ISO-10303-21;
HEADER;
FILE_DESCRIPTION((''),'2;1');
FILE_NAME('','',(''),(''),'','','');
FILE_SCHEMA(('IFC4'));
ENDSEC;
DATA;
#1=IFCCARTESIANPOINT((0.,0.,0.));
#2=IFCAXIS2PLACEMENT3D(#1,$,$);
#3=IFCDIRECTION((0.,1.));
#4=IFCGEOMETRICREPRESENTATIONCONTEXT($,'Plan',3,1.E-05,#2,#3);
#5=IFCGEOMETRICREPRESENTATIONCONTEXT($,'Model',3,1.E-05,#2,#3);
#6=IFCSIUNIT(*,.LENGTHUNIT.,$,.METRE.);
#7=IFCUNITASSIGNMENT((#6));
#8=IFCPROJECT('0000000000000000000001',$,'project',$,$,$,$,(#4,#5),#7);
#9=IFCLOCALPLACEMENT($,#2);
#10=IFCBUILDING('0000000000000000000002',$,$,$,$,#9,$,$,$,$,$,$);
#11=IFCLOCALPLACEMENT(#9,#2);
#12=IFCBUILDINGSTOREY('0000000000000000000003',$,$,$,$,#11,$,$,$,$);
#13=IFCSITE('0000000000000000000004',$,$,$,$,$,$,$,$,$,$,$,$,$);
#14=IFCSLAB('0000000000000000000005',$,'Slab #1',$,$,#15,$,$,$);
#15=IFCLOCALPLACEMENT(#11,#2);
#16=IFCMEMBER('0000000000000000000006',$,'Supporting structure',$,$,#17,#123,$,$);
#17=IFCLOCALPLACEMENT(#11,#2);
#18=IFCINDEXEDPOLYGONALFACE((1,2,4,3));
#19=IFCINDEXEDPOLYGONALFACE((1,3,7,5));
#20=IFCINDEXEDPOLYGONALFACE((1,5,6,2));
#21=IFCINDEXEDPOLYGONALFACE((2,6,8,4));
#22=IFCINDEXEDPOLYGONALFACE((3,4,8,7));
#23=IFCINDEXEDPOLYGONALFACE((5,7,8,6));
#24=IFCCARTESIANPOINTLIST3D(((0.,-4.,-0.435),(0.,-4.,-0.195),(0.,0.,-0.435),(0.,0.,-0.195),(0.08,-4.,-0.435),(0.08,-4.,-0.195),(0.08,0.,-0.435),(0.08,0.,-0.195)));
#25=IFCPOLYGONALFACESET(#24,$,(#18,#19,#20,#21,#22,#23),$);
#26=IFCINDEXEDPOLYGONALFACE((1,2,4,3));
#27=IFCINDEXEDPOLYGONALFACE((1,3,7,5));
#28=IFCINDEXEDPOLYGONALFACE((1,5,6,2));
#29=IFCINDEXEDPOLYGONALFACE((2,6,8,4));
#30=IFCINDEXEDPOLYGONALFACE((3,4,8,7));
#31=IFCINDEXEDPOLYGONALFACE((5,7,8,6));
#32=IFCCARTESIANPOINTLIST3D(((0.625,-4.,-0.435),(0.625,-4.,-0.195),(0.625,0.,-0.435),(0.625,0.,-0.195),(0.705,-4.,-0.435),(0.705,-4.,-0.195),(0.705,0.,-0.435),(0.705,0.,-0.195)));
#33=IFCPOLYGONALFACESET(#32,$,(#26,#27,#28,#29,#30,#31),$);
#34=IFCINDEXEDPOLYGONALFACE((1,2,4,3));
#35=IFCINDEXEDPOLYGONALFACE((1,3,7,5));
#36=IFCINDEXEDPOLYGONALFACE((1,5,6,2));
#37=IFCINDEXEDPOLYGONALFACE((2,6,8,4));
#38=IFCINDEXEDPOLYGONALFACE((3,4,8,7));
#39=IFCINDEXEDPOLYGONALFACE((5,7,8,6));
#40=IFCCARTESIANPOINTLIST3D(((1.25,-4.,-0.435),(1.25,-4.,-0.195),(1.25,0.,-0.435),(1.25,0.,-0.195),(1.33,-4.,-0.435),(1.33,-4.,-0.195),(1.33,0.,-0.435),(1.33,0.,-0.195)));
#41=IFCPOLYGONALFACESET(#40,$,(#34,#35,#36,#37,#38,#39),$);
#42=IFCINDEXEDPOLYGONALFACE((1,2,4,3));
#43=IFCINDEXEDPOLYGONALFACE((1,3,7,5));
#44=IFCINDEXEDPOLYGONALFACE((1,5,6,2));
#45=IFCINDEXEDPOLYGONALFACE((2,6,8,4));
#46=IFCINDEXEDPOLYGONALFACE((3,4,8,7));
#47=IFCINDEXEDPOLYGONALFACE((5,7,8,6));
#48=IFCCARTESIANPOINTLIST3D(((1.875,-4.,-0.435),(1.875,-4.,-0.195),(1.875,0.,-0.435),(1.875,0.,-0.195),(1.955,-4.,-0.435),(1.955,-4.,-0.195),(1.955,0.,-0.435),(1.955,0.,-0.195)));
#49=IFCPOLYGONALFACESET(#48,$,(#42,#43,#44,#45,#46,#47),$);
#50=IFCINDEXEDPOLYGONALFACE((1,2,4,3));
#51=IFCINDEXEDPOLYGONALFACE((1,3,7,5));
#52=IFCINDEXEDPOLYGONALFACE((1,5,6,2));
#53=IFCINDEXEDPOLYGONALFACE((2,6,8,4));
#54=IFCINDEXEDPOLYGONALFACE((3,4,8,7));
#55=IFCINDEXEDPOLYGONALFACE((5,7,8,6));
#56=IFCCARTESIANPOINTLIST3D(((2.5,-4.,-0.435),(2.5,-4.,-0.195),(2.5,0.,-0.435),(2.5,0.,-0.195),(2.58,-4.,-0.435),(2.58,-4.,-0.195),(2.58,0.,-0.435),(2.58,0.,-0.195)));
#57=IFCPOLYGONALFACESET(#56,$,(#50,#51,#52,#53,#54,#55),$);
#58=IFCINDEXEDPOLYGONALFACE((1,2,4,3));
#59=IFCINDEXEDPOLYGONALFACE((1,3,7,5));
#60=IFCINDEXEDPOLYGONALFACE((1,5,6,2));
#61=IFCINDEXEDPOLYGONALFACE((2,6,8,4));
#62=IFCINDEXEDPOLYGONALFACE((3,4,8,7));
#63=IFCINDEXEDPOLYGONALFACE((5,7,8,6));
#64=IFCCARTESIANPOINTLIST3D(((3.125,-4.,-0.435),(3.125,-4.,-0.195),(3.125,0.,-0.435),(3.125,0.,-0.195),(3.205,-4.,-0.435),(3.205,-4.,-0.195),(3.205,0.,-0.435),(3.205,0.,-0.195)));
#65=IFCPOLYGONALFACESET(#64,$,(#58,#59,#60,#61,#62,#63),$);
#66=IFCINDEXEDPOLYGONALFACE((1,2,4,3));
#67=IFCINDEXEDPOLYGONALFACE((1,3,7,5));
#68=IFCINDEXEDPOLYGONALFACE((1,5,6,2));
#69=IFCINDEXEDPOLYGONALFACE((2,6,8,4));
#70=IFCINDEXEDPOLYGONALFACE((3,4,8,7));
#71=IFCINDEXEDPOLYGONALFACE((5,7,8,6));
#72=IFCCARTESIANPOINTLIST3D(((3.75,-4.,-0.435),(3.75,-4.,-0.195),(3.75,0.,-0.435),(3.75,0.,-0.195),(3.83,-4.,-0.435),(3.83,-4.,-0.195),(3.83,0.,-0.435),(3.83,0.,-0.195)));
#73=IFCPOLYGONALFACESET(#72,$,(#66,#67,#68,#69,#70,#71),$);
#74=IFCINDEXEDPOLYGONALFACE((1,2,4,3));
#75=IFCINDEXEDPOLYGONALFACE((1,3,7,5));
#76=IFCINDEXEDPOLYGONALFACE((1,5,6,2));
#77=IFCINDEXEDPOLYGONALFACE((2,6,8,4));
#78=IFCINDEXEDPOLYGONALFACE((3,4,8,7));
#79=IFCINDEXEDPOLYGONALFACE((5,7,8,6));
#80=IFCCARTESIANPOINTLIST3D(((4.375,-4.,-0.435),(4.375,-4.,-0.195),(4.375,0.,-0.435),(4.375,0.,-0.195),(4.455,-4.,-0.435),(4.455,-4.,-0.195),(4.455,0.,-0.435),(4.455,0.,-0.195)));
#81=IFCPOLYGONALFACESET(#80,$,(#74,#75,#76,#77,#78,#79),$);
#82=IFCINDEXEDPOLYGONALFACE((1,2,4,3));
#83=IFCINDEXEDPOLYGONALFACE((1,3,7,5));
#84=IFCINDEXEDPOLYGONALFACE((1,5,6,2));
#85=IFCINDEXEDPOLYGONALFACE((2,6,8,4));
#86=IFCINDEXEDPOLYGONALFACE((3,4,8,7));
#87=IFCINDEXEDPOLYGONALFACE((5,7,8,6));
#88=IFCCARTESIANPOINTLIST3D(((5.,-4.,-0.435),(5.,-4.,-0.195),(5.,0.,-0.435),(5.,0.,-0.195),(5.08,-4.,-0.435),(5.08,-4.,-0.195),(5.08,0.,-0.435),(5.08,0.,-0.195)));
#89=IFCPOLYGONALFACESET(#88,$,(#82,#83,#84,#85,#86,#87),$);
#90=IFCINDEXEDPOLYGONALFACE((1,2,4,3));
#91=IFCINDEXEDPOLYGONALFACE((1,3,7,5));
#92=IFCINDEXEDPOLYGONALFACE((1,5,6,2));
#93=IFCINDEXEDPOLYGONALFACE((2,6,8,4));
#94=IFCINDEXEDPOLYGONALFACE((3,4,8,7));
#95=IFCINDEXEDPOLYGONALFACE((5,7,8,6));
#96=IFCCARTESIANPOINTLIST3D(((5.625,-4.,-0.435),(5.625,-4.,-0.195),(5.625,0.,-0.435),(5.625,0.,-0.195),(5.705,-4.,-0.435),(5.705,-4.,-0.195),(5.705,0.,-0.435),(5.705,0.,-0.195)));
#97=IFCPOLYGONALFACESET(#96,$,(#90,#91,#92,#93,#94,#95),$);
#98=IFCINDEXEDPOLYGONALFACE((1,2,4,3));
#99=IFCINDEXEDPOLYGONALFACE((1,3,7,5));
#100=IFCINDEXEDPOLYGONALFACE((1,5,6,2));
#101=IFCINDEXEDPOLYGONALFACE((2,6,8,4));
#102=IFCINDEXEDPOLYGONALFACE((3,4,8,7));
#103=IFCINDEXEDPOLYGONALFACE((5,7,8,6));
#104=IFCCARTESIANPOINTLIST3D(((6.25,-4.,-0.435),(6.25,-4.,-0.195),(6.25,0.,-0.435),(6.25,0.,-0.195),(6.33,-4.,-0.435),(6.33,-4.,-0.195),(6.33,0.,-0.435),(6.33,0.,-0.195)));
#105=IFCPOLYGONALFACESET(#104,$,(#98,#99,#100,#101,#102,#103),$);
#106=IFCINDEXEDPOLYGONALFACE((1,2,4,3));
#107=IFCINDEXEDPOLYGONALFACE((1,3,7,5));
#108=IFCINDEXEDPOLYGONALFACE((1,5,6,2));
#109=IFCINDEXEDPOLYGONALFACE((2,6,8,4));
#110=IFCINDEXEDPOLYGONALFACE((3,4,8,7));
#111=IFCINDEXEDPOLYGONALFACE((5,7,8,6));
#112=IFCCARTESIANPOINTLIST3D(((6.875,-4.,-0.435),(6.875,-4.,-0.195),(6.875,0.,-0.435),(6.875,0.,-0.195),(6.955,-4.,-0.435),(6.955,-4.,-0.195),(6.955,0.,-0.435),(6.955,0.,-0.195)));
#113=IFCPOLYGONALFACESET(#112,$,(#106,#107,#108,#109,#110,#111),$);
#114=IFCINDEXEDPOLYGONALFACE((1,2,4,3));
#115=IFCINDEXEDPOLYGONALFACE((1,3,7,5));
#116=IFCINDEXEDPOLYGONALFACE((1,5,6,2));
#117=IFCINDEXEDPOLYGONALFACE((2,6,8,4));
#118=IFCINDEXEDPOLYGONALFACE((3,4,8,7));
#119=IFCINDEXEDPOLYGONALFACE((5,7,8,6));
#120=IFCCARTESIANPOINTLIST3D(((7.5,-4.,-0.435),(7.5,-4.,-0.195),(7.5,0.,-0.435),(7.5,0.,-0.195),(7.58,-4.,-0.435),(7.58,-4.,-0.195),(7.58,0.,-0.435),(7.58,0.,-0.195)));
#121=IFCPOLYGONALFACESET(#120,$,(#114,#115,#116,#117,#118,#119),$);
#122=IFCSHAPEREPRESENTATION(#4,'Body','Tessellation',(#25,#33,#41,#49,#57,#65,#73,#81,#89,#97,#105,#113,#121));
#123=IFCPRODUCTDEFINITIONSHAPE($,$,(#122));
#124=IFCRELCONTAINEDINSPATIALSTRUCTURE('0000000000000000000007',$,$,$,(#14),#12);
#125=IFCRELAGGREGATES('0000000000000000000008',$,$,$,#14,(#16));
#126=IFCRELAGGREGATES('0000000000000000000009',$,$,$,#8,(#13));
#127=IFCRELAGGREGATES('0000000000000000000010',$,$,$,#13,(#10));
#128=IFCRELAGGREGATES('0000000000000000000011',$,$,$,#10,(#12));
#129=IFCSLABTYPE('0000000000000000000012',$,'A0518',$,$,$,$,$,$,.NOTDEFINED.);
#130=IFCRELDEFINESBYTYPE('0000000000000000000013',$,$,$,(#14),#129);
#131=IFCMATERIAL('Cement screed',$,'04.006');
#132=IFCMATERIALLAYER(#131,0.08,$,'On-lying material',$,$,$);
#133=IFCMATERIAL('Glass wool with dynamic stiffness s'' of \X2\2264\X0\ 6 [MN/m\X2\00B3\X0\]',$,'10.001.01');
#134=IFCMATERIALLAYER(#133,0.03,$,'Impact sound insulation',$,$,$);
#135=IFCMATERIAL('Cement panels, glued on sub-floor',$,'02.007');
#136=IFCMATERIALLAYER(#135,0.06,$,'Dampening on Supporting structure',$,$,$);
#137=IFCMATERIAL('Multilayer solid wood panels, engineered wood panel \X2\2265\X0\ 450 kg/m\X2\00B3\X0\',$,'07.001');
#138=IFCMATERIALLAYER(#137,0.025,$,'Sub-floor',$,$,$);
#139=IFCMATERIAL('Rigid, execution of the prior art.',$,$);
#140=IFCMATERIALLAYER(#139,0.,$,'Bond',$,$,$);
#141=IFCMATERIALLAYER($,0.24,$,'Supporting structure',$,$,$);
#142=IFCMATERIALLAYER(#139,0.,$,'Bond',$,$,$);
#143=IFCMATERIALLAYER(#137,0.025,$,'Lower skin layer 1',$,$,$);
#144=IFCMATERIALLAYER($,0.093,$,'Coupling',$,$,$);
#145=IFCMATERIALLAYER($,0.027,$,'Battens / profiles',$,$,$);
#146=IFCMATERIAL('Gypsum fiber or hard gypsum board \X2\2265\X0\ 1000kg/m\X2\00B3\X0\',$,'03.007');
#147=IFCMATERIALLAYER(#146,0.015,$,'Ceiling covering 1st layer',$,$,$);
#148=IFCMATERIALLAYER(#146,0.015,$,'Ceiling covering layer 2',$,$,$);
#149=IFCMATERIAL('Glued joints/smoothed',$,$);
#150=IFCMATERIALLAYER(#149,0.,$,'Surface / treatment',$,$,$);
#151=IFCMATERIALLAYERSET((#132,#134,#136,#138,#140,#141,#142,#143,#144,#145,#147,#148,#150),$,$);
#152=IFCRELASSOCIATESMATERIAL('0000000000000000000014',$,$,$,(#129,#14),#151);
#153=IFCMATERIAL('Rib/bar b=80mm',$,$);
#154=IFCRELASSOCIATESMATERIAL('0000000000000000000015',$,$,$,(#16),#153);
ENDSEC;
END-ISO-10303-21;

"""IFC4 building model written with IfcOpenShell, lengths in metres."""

from ifc_helpers import new_model, si_unit, direction, frame, frame_2d, origin, place, context, project, spatial, rectangle, extrude, material, layer, layer_set, type_object, element, aggregate, save


model = new_model("IFC4")

# Units and contexts
plan_context = context("Plan", 3, precision=1e-05, world=origin(), true_north=direction((0.0, 1.0)))
model_context = context("Model", 3, precision=1e-05, world=origin(), true_north=direction((0.0, 1.0)))
ifc_project = project(units=[si_unit("LENGTHUNIT", "METRE")], contexts=[plan_context, model_context])

# Site, building, storey
site = spatial("IfcSite", under=ifc_project)
building_placement = place(None, origin())
building = spatial("IfcBuilding", under=site, at=building_placement)
storey_placement = place(building_placement, origin())
storey = spatial("IfcBuildingStorey", under=building, at=storey_placement)

# Slab, member
ifc_material_1 = material(Name="Cement screed", Category="04.006")
ifc_layer_1 = layer(ifc_material_1, 0.08, Name="On-lying material")
ifc_material_2 = material(Name="Glass wool with dynamic stiffness s' of ≤ 6 [MN/m³]", Category="10.001.01")
ifc_layer_2 = layer(ifc_material_2, 0.03, Name="Impact sound insulation")
ifc_material_3 = material(Name="Cement panels, glued on sub-floor", Category="02.007")
ifc_layer_3 = layer(ifc_material_3, 0.06, Name="Dampening on Supporting structure")
ifc_material_4 = material(Name="Multilayer solid wood panels, engineered wood panel ≥ 450 kg/m³", Category="07.001")
ifc_layer_4 = layer(ifc_material_4, 0.025, Name="Sub-floor")
ifc_material_5 = material(Name="Rigid, execution of the prior art.")
ifc_layer_5 = layer(ifc_material_5, 0.0, Name="Bond")
ifc_layer_6 = layer(None, 0.24, Name="Supporting structure")
ifc_layer_7 = layer(ifc_material_5, 0.0, Name="Bond")
ifc_layer_8 = layer(ifc_material_4, 0.025, Name="Lower skin layer 1")
ifc_layer_9 = layer(None, 0.093, Name="Coupling")
ifc_layer_10 = layer(None, 0.027, Name="Battens / profiles")
ifc_material_6 = material(Name="Gypsum fiber or hard gypsum board ≥ 1000kg/m³", Category="03.007")
ifc_layer_11 = layer(ifc_material_6, 0.015, Name="Ceiling covering 1st layer")
ifc_layer_12 = layer(ifc_material_6, 0.015, Name="Ceiling covering layer 2")
ifc_material_7 = material(Name="Glued joints/smoothed")
ifc_layer_13 = layer(ifc_material_7, 0.0, Name="Surface / treatment")
ifc_layer_set = layer_set([ifc_layer_1, ifc_layer_2, ifc_layer_3, ifc_layer_4, ifc_layer_5, ifc_layer_6, ifc_layer_7, ifc_layer_8, ifc_layer_9, ifc_layer_10, ifc_layer_11, ifc_layer_12, ifc_layer_13])
slab_type = type_object("IfcSlabType", Name="A0518", PredefinedType="NOTDEFINED", material=ifc_layer_set)
slab_placement = place(None, frame((0.0, 0.0, 0.0), z_axis=(0.0, 0.0, -1.0), x_axis=(1.0, 0.0, 0.0)))
slab = element("IfcSlab", 1, at=slab_placement, inside=storey, type_object=slab_type, material=ifc_layer_set, Name="Slab #1")
ifc_material_8 = material(Name="Rib/bar b=80mm")
member_1_placement = place(slab_placement, origin())
member_1 = element("IfcMember", 2, at=member_1_placement, material=ifc_material_8, Name="Supporting structure", context=plan_context, shape_type="SweptSolid", body=[
    extrude(rectangle(XDim=0.08, YDim=0.24, at=frame_2d((0.04, 0.12), x_axis=(1.0, 0.0))), frame((0.0, 4.0, 0.195), z_axis=(0.0, -1.0, 0.0), x_axis=(1.0, 0.0, 0.0)), (0.0, 0.0, 1.0), 4.0),
    extrude(rectangle(XDim=0.08, YDim=0.24, at=frame_2d((0.04, 0.12), x_axis=(1.0, 0.0))), frame((0.625, 4.0, 0.195), z_axis=(0.0, -1.0, 0.0), x_axis=(1.0, 0.0, 0.0)), (0.0, 0.0, 1.0), 4.0),
    extrude(rectangle(XDim=0.08, YDim=0.24, at=frame_2d((0.04, 0.12), x_axis=(1.0, 0.0))), frame((1.25, 4.0, 0.195), z_axis=(0.0, -1.0, 0.0), x_axis=(1.0, 0.0, 0.0)), (0.0, 0.0, 1.0), 4.0),
    extrude(rectangle(XDim=0.08, YDim=0.24, at=frame_2d((0.04, 0.12), x_axis=(1.0, 0.0))), frame((1.875, 4.0, 0.195), z_axis=(0.0, -1.0, 0.0), x_axis=(1.0, 0.0, 0.0)), (0.0, 0.0, 1.0), 4.0),
    extrude(rectangle(XDim=0.08, YDim=0.24, at=frame_2d((0.04, 0.12), x_axis=(1.0, 0.0))), frame((2.5, 4.0, 0.195), z_axis=(0.0, -1.0, 0.0), x_axis=(1.0, 0.0, 0.0)), (0.0, 0.0, 1.0), 4.0),
    extrude(rectangle(XDim=0.08, YDim=0.24, at=frame_2d((0.04, 0.12), x_axis=(1.0, 0.0))), frame((3.125, 4.0, 0.195), z_axis=(0.0, -1.0, 0.0), x_axis=(1.0, 0.0, 0.0)), (0.0, 0.0, 1.0), 4.0),
    extrude(rectangle(XDim=0.08, YDim=0.24, at=frame_2d((0.04, 0.12), x_axis=(1.0, 0.0))), frame((3.75, 4.0, 0.195), z_axis=(0.0, -1.0, 0.0), x_axis=(1.0, 0.0, 0.0)), (0.0, 0.0, 1.0), 4.0),
    extrude(rectangle(XDim=0.08, YDim=0.24, at=frame_2d((0.04, 0.12), x_axis=(1.0, 0.0))), frame((4.375, 4.0, 0.195), z_axis=(0.0, -1.0, 0.0), x_axis=(1.0, 0.0, 0.0)), (0.0, 0.0, 1.0), 4.0),
    extrude(rectangle(XDim=0.08, YDim=0.24, at=frame_2d((0.04, 0.12), x_axis=(1.0, 0.0))), frame((5.0, 4.0, 0.195), z_axis=(0.0, -1.0, 0.0), x_axis=(1.0, 0.0, 0.0)), (0.0, 0.0, 1.0), 4.0),
    extrude(rectangle(XDim=0.08, YDim=0.24, at=frame_2d((0.04, 0.12), x_axis=(1.0, 0.0))), frame((5.625, 4.0, 0.195), z_axis=(0.0, -1.0, 0.0), x_axis=(1.0, 0.0, 0.0)), (0.0, 0.0, 1.0), 4.0),
    extrude(rectangle(XDim=0.08, YDim=0.24, at=frame_2d((0.04, 0.12), x_axis=(1.0, 0.0))), frame((6.25, 4.0, 0.195), z_axis=(0.0, -1.0, 0.0), x_axis=(1.0, 0.0, 0.0)), (0.0, 0.0, 1.0), 4.0),
    extrude(rectangle(XDim=0.08, YDim=0.24, at=frame_2d((0.04, 0.12), x_axis=(1.0, 0.0))), frame((6.875, 4.0, 0.195), z_axis=(0.0, -1.0, 0.0), x_axis=(1.0, 0.0, 0.0)), (0.0, 0.0, 1.0), 4.0),
    extrude(rectangle(XDim=0.08, YDim=0.24, at=frame_2d((0.04, 0.12), x_axis=(1.0, 0.0))), frame((7.5, 4.0, 0.195), z_axis=(0.0, -1.0, 0.0), x_axis=(1.0, 0.0, 0.0)), (0.0, 0.0, 1.0), 4.0),
])
aggregate(slab, [member_1])

save(model, "model.ifc")
